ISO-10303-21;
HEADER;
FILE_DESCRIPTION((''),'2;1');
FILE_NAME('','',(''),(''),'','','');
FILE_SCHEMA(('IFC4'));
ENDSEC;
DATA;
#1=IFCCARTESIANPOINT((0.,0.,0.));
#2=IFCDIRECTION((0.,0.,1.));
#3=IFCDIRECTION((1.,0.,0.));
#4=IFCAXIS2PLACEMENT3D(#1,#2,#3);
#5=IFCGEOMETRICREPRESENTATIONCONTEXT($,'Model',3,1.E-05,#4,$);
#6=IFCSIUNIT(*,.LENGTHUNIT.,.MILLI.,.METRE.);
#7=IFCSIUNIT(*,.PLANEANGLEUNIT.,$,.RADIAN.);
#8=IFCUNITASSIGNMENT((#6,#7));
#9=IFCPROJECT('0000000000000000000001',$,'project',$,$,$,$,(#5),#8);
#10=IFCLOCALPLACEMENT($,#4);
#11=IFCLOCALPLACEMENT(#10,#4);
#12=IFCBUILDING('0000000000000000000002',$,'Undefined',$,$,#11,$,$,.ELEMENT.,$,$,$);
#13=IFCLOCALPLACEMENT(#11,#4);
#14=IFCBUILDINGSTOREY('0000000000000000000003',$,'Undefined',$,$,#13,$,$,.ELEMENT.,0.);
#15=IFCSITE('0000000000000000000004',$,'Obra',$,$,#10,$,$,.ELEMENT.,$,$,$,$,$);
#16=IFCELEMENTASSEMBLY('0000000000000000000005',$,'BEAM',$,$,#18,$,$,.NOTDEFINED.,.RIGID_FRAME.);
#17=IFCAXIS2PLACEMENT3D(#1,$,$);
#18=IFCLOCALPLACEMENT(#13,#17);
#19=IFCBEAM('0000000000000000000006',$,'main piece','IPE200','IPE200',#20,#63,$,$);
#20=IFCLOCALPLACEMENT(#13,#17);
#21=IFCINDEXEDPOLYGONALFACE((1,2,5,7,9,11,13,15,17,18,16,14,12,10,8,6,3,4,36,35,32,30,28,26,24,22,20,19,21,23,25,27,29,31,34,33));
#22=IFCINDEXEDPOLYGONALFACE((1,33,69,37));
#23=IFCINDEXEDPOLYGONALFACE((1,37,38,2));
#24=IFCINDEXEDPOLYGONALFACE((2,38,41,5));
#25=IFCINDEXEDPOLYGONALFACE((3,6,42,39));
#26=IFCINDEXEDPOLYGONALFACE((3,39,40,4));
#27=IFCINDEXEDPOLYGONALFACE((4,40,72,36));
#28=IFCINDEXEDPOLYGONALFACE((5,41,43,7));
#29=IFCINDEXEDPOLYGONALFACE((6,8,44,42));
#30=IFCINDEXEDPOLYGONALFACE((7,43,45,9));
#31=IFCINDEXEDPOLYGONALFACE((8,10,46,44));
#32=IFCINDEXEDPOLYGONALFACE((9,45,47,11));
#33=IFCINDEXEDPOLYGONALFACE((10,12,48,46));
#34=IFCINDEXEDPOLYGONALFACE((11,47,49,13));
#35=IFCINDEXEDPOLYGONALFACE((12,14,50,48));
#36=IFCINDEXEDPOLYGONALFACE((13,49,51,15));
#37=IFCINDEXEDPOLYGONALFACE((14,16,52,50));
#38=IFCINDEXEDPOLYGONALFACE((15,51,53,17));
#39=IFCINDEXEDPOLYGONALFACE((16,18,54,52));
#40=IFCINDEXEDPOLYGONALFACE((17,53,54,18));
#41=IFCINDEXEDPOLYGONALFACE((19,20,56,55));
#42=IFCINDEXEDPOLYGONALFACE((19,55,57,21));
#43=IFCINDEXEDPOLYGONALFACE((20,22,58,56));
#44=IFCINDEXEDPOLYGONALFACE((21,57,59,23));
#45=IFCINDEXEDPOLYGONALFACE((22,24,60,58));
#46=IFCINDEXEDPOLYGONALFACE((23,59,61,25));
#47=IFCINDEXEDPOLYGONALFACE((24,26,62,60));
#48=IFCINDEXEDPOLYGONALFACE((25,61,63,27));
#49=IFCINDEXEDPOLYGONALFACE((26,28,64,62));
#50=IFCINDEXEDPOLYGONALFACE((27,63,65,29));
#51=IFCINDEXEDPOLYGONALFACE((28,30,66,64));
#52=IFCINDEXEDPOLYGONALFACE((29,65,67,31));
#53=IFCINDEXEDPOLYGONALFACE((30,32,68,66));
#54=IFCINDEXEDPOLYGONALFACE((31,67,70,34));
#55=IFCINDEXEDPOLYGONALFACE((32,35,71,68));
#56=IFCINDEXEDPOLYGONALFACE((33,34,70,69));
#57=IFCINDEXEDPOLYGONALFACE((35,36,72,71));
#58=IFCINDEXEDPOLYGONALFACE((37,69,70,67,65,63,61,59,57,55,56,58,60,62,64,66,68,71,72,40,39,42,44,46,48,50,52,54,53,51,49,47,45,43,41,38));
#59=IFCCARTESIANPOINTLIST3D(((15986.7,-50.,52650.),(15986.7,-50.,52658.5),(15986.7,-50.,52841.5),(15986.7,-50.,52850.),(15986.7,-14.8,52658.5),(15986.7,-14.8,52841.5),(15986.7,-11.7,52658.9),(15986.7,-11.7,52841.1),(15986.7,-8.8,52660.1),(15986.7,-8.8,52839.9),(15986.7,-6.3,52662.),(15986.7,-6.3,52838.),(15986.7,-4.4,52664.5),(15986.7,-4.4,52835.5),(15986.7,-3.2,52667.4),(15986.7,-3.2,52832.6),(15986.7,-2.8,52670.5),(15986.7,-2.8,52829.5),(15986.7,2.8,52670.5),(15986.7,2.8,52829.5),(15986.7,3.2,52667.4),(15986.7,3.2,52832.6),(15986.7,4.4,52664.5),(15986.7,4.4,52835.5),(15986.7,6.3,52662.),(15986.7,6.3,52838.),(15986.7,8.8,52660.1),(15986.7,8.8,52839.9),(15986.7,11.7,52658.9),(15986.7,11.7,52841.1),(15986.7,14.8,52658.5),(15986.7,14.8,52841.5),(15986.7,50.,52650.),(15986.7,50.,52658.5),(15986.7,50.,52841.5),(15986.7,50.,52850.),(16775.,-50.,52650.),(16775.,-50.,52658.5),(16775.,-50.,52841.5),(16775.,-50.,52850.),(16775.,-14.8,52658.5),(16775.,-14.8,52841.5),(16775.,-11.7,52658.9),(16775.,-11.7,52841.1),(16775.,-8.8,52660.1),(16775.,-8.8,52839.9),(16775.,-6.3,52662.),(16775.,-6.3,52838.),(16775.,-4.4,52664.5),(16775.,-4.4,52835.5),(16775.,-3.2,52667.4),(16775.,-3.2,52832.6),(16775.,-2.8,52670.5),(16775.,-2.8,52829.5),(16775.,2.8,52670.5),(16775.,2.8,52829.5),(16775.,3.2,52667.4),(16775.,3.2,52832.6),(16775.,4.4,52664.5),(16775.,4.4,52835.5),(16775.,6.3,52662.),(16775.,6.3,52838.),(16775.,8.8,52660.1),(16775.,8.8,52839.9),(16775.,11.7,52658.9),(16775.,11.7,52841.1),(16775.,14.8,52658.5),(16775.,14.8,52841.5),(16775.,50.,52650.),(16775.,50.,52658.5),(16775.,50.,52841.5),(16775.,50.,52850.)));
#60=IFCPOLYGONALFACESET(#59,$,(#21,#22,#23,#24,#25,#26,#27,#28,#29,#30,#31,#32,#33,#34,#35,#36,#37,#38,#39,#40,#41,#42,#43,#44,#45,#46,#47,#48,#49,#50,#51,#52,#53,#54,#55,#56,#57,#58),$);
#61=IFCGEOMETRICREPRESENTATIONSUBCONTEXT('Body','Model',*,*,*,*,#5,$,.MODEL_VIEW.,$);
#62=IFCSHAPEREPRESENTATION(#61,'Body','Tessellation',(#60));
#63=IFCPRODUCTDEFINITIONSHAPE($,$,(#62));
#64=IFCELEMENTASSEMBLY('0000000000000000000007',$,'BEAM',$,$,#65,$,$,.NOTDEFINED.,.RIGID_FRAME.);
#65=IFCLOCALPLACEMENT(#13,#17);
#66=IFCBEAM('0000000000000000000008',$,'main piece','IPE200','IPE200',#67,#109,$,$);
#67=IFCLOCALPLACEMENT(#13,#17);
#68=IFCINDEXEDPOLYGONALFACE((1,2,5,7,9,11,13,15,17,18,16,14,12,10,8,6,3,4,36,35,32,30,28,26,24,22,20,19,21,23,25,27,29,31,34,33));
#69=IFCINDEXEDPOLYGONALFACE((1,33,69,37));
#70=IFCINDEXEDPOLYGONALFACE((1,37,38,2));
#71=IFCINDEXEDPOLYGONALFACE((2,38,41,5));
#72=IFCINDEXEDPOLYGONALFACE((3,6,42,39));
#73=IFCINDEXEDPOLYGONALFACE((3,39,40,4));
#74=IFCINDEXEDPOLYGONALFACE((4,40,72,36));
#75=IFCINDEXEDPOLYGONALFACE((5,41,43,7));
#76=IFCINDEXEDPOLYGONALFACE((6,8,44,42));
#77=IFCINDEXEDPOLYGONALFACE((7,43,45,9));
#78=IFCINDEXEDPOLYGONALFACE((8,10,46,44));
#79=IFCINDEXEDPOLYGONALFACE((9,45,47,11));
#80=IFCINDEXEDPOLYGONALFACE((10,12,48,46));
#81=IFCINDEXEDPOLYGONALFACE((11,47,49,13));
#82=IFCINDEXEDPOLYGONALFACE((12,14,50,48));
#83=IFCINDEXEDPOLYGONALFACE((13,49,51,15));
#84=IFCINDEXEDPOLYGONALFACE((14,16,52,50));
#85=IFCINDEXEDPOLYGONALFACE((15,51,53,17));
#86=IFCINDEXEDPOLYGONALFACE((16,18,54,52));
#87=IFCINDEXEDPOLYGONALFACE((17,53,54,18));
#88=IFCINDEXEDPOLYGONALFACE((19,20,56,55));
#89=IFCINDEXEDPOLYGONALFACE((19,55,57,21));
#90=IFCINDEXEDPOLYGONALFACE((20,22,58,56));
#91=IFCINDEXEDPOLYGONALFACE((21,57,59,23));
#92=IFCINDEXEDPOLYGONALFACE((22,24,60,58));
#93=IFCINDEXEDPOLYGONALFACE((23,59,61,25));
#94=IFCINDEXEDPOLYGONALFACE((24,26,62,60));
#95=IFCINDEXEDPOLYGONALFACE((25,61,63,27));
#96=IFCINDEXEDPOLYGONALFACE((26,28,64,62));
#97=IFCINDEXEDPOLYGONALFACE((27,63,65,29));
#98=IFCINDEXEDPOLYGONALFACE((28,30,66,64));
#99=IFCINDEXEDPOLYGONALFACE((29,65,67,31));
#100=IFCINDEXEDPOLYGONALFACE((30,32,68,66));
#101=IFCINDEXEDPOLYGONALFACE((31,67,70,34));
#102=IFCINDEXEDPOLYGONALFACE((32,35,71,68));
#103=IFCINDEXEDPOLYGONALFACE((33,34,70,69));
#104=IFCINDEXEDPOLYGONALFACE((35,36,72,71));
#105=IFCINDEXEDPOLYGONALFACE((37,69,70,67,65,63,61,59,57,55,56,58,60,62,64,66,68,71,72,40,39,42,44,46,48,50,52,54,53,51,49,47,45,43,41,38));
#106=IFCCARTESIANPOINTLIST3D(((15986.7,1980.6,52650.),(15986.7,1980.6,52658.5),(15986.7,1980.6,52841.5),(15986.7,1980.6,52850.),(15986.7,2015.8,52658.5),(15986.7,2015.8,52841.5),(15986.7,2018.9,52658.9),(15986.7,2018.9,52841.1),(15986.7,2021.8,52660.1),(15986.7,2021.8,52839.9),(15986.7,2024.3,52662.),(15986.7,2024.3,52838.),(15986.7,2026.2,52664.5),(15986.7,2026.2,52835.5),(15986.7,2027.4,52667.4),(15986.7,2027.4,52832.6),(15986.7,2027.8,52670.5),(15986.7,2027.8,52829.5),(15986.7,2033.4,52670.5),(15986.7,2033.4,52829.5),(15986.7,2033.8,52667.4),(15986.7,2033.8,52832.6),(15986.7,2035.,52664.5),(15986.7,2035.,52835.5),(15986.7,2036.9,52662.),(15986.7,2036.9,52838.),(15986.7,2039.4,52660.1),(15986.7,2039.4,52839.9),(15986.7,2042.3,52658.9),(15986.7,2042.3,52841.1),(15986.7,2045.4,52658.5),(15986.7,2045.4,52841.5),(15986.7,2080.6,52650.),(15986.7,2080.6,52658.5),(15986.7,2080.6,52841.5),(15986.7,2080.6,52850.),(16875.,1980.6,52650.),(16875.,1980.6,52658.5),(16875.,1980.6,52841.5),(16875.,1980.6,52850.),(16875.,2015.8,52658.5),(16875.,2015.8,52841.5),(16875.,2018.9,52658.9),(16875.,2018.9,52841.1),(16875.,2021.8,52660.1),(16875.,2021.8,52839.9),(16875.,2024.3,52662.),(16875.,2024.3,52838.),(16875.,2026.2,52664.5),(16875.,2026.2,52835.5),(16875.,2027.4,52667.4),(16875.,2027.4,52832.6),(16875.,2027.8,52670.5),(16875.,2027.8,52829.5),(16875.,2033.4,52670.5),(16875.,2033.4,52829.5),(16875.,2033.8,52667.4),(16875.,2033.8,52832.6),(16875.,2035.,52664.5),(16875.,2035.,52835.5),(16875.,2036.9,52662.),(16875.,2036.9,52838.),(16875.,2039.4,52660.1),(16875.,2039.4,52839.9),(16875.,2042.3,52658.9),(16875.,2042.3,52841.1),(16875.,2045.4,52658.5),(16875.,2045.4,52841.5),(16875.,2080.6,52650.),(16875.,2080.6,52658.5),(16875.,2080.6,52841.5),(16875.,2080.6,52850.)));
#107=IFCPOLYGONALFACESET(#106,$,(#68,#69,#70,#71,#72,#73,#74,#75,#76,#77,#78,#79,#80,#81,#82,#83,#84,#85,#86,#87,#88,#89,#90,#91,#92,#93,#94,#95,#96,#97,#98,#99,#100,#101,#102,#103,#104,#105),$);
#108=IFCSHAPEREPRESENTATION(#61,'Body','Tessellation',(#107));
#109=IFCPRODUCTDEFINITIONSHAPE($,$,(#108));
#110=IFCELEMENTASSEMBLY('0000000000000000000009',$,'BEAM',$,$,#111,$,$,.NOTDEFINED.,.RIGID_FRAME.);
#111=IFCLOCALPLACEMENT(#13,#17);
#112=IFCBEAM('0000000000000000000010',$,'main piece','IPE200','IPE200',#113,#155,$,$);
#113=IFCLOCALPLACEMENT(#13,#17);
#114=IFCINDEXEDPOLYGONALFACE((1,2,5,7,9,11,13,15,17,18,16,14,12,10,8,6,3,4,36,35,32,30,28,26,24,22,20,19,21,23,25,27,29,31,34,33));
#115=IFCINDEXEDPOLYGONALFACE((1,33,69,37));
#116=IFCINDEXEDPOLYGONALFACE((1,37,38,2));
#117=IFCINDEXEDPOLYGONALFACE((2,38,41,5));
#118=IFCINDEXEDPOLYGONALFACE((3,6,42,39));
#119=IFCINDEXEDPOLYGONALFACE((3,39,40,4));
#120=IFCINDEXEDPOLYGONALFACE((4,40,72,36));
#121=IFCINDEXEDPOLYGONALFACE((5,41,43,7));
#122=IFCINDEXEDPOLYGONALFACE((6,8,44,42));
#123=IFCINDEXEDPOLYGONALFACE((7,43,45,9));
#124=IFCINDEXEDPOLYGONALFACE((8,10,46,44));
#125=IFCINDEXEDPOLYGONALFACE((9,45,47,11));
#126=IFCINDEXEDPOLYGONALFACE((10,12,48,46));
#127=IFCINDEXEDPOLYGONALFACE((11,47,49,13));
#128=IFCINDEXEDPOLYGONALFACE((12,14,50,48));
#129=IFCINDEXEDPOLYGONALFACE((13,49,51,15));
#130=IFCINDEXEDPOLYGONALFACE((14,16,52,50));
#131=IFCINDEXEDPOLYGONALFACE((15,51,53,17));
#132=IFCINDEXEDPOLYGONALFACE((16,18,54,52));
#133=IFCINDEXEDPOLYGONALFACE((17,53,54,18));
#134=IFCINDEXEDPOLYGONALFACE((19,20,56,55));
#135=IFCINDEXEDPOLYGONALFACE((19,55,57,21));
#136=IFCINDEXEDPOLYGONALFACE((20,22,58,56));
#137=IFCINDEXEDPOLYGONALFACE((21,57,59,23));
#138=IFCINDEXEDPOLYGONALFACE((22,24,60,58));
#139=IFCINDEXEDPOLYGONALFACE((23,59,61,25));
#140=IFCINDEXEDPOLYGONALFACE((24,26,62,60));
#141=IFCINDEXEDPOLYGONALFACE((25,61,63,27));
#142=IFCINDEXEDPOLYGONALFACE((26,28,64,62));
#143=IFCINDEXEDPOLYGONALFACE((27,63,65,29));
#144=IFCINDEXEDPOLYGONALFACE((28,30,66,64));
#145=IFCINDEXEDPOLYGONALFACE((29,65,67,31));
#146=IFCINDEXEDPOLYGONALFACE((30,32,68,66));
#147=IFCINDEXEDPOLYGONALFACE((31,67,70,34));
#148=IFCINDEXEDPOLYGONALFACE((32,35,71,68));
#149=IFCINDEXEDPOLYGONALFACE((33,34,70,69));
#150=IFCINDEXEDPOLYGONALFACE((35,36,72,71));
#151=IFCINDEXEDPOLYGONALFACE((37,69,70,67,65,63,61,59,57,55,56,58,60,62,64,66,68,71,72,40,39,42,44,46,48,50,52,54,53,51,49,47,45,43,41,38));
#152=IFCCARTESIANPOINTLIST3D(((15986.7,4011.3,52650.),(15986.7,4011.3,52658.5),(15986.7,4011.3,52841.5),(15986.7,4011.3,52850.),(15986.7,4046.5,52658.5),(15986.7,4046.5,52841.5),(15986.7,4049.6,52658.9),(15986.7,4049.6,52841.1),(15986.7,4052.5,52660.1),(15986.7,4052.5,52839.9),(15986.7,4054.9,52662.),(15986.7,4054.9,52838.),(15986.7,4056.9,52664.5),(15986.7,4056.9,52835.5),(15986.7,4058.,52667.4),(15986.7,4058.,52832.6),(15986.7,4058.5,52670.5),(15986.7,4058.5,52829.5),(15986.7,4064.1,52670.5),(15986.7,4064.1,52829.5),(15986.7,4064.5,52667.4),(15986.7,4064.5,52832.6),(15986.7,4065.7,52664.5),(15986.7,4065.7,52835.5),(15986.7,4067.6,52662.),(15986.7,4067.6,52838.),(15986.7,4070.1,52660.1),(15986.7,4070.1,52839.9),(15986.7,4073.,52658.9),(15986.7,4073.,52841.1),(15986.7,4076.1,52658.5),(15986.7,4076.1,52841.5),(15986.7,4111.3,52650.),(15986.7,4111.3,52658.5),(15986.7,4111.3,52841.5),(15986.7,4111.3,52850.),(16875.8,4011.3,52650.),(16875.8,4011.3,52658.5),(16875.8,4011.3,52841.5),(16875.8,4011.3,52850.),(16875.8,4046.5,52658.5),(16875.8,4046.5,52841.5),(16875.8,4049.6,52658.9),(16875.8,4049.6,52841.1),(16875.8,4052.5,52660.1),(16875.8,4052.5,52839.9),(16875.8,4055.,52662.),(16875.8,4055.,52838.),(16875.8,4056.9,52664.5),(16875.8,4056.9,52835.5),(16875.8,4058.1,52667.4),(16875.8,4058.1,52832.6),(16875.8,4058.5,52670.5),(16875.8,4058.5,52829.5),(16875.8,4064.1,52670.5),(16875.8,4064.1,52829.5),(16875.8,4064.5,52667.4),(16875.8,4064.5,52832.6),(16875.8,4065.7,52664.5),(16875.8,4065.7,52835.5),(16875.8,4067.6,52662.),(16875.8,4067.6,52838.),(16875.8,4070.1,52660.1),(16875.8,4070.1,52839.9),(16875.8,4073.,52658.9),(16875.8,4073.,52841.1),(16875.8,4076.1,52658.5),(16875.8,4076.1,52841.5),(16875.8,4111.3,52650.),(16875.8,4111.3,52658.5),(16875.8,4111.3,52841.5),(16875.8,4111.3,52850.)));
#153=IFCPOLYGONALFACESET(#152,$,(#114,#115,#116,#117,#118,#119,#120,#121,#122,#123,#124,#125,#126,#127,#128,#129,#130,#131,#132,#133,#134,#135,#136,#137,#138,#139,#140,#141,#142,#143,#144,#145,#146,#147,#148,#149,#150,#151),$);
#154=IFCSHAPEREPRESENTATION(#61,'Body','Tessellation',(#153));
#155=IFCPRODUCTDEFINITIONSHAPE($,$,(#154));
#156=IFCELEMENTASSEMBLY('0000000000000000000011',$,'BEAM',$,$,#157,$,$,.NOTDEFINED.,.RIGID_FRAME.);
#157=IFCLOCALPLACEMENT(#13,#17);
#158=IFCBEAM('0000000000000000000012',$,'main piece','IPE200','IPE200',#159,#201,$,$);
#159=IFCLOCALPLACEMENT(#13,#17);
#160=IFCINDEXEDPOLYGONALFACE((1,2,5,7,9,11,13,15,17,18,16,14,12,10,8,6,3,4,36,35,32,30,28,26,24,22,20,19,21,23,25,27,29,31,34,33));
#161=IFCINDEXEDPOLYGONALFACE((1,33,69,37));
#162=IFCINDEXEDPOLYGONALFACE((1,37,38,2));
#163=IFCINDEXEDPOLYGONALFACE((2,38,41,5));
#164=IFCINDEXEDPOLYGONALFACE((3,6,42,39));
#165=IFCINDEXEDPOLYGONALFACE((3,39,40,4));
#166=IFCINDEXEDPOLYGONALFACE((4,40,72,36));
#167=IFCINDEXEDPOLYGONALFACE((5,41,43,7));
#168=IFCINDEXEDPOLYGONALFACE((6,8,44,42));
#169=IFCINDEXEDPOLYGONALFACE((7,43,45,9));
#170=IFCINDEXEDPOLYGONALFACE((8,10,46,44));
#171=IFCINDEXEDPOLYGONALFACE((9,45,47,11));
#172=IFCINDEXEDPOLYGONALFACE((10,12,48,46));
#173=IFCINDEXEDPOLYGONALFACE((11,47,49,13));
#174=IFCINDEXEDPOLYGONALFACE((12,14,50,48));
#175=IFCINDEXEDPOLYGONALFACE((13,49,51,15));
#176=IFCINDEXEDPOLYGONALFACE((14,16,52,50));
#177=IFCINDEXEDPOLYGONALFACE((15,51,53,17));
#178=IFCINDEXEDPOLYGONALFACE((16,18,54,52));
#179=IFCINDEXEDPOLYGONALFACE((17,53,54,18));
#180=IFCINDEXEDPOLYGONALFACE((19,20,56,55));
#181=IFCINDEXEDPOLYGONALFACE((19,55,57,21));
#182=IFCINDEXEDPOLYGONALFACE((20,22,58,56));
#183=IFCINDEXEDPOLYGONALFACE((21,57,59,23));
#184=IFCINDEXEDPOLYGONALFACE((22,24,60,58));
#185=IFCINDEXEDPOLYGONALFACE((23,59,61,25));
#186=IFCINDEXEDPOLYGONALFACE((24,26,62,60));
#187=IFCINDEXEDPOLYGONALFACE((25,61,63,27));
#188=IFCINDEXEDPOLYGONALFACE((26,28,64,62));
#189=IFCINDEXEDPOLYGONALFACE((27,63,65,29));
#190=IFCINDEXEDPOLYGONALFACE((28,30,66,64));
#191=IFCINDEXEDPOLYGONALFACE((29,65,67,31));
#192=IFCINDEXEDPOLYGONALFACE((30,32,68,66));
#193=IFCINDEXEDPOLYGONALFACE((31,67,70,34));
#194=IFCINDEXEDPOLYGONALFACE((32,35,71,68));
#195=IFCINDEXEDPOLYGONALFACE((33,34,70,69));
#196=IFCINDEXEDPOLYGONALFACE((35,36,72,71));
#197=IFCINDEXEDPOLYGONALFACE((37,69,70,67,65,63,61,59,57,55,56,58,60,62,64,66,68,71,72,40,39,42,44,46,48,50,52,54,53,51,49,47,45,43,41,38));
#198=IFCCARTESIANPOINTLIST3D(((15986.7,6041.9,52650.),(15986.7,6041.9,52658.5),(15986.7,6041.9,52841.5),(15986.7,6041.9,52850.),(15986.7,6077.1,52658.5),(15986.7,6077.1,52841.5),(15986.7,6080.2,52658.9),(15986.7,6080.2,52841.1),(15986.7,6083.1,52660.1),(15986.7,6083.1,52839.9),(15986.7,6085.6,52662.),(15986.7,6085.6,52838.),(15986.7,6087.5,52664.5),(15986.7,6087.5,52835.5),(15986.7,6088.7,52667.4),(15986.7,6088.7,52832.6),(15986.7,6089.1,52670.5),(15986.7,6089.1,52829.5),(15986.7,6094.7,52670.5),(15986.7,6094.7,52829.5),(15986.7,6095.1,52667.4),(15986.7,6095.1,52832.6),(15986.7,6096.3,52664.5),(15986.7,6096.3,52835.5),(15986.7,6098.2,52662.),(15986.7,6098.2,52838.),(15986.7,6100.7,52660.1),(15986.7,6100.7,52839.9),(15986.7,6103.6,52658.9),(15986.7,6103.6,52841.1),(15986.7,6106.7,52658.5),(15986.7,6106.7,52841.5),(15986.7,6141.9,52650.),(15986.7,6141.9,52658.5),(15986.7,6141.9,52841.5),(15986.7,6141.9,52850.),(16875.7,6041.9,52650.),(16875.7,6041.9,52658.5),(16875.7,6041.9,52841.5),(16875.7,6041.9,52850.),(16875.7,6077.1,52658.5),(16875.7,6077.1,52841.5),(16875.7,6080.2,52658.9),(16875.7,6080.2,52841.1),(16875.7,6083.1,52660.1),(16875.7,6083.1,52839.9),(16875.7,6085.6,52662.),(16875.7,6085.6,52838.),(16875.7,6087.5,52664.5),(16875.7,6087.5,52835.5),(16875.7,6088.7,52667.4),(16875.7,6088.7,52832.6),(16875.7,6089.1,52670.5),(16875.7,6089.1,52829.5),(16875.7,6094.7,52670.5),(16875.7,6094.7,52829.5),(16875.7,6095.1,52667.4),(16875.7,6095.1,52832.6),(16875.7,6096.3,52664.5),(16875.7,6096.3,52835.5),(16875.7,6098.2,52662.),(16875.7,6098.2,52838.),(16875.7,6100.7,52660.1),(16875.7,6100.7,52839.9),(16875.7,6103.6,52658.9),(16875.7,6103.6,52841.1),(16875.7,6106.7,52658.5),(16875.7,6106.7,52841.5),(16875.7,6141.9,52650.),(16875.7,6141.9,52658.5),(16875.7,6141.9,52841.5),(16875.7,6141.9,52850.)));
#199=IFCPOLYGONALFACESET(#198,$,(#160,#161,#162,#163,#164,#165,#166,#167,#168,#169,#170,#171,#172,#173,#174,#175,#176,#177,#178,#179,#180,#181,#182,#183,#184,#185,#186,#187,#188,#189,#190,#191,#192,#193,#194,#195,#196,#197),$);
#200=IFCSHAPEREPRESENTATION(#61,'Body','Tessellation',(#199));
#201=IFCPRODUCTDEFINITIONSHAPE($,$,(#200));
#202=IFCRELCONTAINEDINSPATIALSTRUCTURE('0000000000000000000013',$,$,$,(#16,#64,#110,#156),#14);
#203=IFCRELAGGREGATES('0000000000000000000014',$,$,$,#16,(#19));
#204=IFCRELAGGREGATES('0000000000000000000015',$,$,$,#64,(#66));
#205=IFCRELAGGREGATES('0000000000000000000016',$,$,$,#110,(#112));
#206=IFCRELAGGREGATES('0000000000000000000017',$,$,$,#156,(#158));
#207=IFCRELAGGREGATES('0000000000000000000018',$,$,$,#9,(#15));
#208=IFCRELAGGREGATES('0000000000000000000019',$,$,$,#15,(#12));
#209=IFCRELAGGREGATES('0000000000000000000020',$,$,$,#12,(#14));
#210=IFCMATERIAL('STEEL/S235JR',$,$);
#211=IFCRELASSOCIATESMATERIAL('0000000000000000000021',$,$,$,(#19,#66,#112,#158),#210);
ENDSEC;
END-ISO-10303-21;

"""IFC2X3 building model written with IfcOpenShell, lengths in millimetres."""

from ifc_helpers import new_model, si_unit, frame, origin_with_axes, origin_2d_with_axis, place, context, subcontext, project, spatial, i_section, extrude, material, element, aggregate, save


model = new_model("IFC2X3")

# Units and contexts
model_context = context("Model", 3, precision=1e-05, world=origin_with_axes())
body_context = subcontext(model_context, "Body", "Model", "MODEL_VIEW")
ifc_project = project(units=[si_unit("LENGTHUNIT", "METRE", prefix="MILLI"), si_unit("PLANEANGLEUNIT", "RADIAN")], contexts=[model_context])

# Site, building, storey
site_placement = place(None, origin_with_axes())
site = spatial("IfcSite", under=ifc_project, at=site_placement, Name="Obra", CompositionType="ELEMENT")
building_placement = place(site_placement, origin_with_axes())
building = spatial("IfcBuilding", under=site, at=building_placement, Name="Undefined", CompositionType="ELEMENT")
storey_placement = place(building_placement, origin_with_axes())
storey = spatial("IfcBuildingStorey", under=building, at=storey_placement, Name="Undefined", CompositionType="ELEMENT", Elevation=0.0)

# Shared definitions
ifc_material_1 = material(Name="STEEL/S235JR")

# Element assemblies, beams
assembly_1_placement = place(storey_placement, origin_with_axes())
assembly_1 = element("IfcElementAssembly", 1, at=assembly_1_placement, inside=storey, Name="BEAM", AssemblyPlace="NOTDEFINED", PredefinedType="RIGID_FRAME")
beam_1_placement = place(assembly_1_placement, frame((16775.0, 0.0, 52750.0), z_axis=(0.0, 0.0, 1.0), x_axis=(-1.0, 0.0, 0.0)))
beam_1 = element("IfcBeam", 2, at=beam_1_placement, material=ifc_material_1, Name="main piece", Description="IPE200", ObjectType="IPE200", context=body_context, shape_type="SweptSolid", body=[
    extrude(i_section(OverallWidth=100.0, OverallDepth=200.0, WebThickness=5.6, FlangeThickness=8.5, FilletRadius=12.0, at=origin_2d_with_axis()), frame((788.3, 0.0, 0.0), z_axis=(-1.0, 0.0, 0.0), x_axis=(0.0, -1.0, 0.0)), (0.0, 0.0, 1.0), 788.3),
])
aggregate(assembly_1, [beam_1])
assembly_2_placement = place(storey_placement, origin_with_axes())
assembly_2 = element("IfcElementAssembly", 3, at=assembly_2_placement, inside=storey, Name="BEAM", AssemblyPlace="NOTDEFINED", PredefinedType="RIGID_FRAME")
beam_2_placement = place(assembly_2_placement, frame((16875.0, 2030.6, 52750.0), z_axis=(0.0, 0.0, 1.0), x_axis=(-1.0, 0.0, 0.0)))
beam_2 = element("IfcBeam", 4, at=beam_2_placement, material=ifc_material_1, Name="main piece", Description="IPE200", ObjectType="IPE200", context=body_context, shape_type="SweptSolid", body=[
    extrude(i_section(OverallWidth=100.0, OverallDepth=200.0, WebThickness=5.6, FlangeThickness=8.5, FilletRadius=12.0, at=origin_2d_with_axis()), frame((888.3, 0.0, 0.0), z_axis=(-1.0, 0.0, 0.0), x_axis=(0.0, -1.0, 0.0)), (0.0, 0.0, 1.0), 888.3),
])
aggregate(assembly_2, [beam_2])
assembly_3_placement = place(storey_placement, origin_with_axes())
assembly_3 = element("IfcElementAssembly", 5, at=assembly_3_placement, inside=storey, Name="BEAM", AssemblyPlace="NOTDEFINED", PredefinedType="RIGID_FRAME")
beam_3_placement = place(assembly_3_placement, frame((16875.8, 4061.3, 52750.0), z_axis=(0.0, 0.0, 1.0), x_axis=(-1.0, -0.000044, 0.0)))
beam_3 = element("IfcBeam", 6, at=beam_3_placement, material=ifc_material_1, Name="main piece", Description="IPE200", ObjectType="IPE200", context=body_context, shape_type="SweptSolid", body=[
    extrude(i_section(OverallWidth=100.0, OverallDepth=200.0, WebThickness=5.6, FlangeThickness=8.5, FilletRadius=12.0, at=origin_2d_with_axis()), frame((889.1, 0.0, 0.0), z_axis=(-1.0, 0.0, 0.0), x_axis=(0.0, -1.0, 0.0)), (0.0, 0.0, 1.0), 889.1),
])
aggregate(assembly_3, [beam_3])
assembly_4_placement = place(storey_placement, origin_with_axes())
assembly_4 = element("IfcElementAssembly", 7, at=assembly_4_placement, inside=storey, Name="BEAM", AssemblyPlace="NOTDEFINED", PredefinedType="RIGID_FRAME")
beam_4_placement = place(assembly_4_placement, frame((16875.7, 6091.9, 52750.0), z_axis=(0.0, 0.0, 1.0), x_axis=(-1.0, 0.0, 0.0)))
beam_4 = element("IfcBeam", 8, at=beam_4_placement, material=ifc_material_1, Name="main piece", Description="IPE200", ObjectType="IPE200", context=body_context, shape_type="SweptSolid", body=[
    extrude(i_section(OverallWidth=100.0, OverallDepth=200.0, WebThickness=5.6, FlangeThickness=8.5, FilletRadius=12.0, at=origin_2d_with_axis()), frame((889.0, 0.0, 0.0), z_axis=(-1.0, 0.0, 0.0), x_axis=(0.0, -1.0, 0.0)), (0.0, 0.0, 1.0), 889.0),
])
aggregate(assembly_4, [beam_4])

save(model, "model.ifc")
